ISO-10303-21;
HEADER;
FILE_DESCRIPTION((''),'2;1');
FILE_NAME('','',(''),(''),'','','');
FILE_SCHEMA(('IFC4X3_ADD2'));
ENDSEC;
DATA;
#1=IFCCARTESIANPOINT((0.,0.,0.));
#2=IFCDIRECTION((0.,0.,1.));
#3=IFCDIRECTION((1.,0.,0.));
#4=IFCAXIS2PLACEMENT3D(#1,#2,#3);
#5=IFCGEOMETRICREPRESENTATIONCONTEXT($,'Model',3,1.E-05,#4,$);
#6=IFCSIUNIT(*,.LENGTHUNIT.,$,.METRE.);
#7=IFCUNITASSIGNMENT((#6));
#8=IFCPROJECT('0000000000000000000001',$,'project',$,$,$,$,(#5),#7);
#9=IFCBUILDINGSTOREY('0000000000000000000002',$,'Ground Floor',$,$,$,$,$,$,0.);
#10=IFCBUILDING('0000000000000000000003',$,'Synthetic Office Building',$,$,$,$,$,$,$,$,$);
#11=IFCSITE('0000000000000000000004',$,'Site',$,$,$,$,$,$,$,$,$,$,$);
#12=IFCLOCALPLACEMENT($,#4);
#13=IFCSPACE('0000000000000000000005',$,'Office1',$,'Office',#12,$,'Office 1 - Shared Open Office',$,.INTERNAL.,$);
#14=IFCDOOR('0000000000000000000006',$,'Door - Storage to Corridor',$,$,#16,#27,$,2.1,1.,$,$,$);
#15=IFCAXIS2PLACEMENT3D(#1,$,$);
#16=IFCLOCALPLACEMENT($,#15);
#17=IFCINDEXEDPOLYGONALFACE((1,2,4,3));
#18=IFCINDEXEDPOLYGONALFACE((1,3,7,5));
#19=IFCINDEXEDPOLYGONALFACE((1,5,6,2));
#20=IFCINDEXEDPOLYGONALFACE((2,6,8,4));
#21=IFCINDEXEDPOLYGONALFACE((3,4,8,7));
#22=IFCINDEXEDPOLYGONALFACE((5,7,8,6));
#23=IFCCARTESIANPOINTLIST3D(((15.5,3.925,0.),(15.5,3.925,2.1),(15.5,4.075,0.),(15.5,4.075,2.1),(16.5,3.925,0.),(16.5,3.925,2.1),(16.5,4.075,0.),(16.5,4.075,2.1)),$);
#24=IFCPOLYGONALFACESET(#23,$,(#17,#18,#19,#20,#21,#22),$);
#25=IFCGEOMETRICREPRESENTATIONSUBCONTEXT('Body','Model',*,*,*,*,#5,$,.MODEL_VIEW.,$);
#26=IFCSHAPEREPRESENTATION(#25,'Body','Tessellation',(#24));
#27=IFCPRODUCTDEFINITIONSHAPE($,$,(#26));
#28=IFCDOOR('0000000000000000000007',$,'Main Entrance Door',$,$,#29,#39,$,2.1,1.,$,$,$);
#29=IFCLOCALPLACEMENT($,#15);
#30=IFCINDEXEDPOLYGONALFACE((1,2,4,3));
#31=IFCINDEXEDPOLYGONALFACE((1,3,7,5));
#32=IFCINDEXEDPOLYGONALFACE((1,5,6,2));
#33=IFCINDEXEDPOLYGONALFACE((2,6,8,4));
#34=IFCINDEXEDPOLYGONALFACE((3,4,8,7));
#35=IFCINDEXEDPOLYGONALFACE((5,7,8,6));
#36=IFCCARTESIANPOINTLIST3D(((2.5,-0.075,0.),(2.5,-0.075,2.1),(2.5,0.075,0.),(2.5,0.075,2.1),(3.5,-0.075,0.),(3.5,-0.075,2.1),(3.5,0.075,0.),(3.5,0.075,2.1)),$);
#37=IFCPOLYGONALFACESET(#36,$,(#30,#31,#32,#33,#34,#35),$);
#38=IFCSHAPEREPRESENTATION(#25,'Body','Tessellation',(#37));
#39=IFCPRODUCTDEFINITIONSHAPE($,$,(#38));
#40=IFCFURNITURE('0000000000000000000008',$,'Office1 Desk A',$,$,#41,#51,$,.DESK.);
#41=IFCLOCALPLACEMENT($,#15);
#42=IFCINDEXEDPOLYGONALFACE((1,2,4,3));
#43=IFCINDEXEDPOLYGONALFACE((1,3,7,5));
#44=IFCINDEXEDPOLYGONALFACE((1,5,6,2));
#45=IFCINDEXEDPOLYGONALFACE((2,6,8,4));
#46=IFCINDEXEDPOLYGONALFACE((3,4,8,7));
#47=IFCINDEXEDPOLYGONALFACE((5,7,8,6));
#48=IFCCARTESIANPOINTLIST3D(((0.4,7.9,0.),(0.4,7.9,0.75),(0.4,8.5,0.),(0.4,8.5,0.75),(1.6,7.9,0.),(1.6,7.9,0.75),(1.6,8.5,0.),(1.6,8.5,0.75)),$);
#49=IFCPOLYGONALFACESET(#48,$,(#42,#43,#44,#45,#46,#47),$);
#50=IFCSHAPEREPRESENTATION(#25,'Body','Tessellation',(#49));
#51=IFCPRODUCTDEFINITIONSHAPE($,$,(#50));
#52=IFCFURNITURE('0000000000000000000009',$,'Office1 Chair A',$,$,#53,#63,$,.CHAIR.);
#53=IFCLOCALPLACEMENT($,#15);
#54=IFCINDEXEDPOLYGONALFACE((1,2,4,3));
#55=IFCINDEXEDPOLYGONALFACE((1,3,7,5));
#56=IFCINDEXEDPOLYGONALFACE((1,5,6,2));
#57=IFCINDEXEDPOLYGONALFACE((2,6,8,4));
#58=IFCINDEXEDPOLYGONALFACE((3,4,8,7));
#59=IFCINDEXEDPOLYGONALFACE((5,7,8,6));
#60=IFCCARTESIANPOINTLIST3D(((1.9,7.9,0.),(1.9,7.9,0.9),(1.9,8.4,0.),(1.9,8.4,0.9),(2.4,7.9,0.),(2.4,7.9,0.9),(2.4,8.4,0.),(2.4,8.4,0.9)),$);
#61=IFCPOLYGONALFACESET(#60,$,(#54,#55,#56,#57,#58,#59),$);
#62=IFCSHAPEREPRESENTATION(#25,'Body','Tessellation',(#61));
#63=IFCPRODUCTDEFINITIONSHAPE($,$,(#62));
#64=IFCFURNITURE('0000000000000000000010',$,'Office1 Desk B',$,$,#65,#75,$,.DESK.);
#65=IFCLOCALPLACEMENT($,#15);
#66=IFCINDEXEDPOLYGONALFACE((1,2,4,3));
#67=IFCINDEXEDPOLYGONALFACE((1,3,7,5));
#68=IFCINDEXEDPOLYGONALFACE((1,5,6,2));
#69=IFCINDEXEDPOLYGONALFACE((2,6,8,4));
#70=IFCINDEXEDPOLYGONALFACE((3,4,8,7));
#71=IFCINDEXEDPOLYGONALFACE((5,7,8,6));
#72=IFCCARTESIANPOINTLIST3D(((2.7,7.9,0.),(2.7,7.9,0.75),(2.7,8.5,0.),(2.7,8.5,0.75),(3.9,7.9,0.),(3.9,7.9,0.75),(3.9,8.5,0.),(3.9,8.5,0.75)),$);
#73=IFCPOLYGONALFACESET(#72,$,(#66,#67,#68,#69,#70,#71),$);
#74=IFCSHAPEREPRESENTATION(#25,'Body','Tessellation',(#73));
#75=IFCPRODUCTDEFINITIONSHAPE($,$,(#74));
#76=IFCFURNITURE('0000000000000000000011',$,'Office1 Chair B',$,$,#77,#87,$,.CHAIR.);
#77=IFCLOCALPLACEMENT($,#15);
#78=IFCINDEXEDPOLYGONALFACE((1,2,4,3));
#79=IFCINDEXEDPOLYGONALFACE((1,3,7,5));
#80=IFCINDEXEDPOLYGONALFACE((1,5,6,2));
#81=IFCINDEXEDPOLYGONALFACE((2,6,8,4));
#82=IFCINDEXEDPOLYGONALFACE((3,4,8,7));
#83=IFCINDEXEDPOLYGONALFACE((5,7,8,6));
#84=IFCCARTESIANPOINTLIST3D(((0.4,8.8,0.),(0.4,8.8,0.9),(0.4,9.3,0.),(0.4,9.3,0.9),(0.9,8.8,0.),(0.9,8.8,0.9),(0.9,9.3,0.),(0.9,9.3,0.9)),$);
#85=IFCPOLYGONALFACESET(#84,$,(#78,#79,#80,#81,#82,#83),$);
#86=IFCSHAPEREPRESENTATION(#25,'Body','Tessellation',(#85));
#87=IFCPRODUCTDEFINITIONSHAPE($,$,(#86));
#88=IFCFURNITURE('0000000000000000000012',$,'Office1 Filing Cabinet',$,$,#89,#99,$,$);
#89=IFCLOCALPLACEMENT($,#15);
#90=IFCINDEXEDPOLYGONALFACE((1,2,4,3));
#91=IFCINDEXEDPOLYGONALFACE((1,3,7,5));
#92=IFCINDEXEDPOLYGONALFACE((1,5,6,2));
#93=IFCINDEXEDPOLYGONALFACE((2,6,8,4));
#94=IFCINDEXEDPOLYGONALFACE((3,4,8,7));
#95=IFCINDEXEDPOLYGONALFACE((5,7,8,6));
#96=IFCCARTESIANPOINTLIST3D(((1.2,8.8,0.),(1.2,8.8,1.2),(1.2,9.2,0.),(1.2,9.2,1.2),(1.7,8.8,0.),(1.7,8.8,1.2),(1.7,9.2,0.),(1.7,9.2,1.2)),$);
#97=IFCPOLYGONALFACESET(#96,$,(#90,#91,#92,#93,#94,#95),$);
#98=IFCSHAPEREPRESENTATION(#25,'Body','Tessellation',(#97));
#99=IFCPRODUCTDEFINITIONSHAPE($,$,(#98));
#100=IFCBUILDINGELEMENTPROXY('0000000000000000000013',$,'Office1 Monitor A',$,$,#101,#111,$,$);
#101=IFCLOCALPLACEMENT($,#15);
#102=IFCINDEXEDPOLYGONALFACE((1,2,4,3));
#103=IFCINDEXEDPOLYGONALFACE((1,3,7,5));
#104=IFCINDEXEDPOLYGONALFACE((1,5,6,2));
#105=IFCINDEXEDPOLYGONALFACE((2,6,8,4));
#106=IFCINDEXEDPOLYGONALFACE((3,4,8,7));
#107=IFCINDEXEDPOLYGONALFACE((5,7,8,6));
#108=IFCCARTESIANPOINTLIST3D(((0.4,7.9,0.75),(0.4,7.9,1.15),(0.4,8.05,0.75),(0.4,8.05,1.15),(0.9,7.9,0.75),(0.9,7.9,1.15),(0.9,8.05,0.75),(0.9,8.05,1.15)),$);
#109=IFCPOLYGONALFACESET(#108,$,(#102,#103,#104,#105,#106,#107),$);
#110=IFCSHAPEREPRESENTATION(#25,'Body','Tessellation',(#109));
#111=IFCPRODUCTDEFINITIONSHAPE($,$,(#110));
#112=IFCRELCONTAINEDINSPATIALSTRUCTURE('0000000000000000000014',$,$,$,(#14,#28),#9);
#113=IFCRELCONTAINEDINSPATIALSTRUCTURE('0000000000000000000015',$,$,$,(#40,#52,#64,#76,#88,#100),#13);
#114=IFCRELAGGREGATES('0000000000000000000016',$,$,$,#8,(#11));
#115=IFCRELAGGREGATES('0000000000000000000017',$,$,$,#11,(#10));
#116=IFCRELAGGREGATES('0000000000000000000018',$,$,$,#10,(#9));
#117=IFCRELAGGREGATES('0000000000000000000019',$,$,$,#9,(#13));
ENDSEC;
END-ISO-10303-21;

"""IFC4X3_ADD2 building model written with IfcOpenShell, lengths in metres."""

from ifc_helpers import new_model, si_unit, frame, origin_with_axes, place, context, subcontext, project, spatial, polyline, outline, extrude, element, save


model = new_model("IFC4X3_ADD2")

# Units and contexts
model_context = context("Model", 3, precision=1e-05, world=origin_with_axes())
body_context = subcontext(model_context, "Body", "Model", "MODEL_VIEW")
ifc_project = project(units=[si_unit("LENGTHUNIT", "METRE")], contexts=[model_context])

# Site, building, storey
site = spatial("IfcSite", under=ifc_project, Name="Site")
building = spatial("IfcBuilding", under=site, Name="Synthetic Office Building")
storey = spatial("IfcBuildingStorey", under=building, Name="Ground Floor", Elevation=0.0)

# Doors
door_1_placement = place(None, origin_with_axes())
element("IfcDoor", 1, at=door_1_placement, inside=storey, Name="Door - Storage to Corridor", OverallHeight=2.1, OverallWidth=1.0, context=body_context, shape_type="SweptSolid", body=[
    extrude(outline(polyline([(15.5, 3.925), (16.5, 3.925), (16.5, 4.075), (15.5, 4.075), (15.5, 3.925)])), origin_with_axes(), (0.0, 0.0, 1.0), 2.1),
])
door_2_placement = place(None, origin_with_axes())
element("IfcDoor", 2, at=door_2_placement, inside=storey, Name="Main Entrance Door", OverallHeight=2.1, OverallWidth=1.0, context=body_context, shape_type="SweptSolid", body=[
    extrude(outline(polyline([(2.5, -0.075), (3.5, -0.075), (3.5, 0.075), (2.5, 0.075), (2.5, -0.075)])), origin_with_axes(), (0.0, 0.0, 1.0), 2.1),
])

# Shared definitions
space_placement = place(None, origin_with_axes())
space = spatial("IfcSpace", under=storey, at=space_placement, Name="Office1", ObjectType="Office", LongName="Office 1 - Shared Open Office", PredefinedType="INTERNAL")

# Furniture
furniture_1_placement = place(space_placement, origin_with_axes())
element("IfcFurniture", 3, at=furniture_1_placement, inside=space, Name="Office1 Desk A", PredefinedType="DESK", context=body_context, shape_type="SweptSolid", body=[
    extrude(outline(polyline([(0.4, 7.9), (1.6, 7.9), (1.6, 8.5), (0.4, 8.5), (0.4, 7.9)])), origin_with_axes(), (0.0, 0.0, 1.0), 0.75),
])
furniture_2_placement = place(space_placement, origin_with_axes())
element("IfcFurniture", 4, at=furniture_2_placement, inside=space, Name="Office1 Chair A", PredefinedType="CHAIR", context=body_context, shape_type="SweptSolid", body=[
    extrude(outline(polyline([(1.9, 7.9), (2.4, 7.9), (2.4, 8.4), (1.9, 8.4), (1.9, 7.9)])), origin_with_axes(), (0.0, 0.0, 1.0), 0.9),
])
furniture_3_placement = place(space_placement, origin_with_axes())
element("IfcFurniture", 5, at=furniture_3_placement, inside=space, Name="Office1 Desk B", PredefinedType="DESK", context=body_context, shape_type="SweptSolid", body=[
    extrude(outline(polyline([(2.7, 7.9), (3.9, 7.9), (3.9, 8.5), (2.7, 8.5), (2.7, 7.9)])), origin_with_axes(), (0.0, 0.0, 1.0), 0.75),
])
furniture_4_placement = place(space_placement, origin_with_axes())
element("IfcFurniture", 6, at=furniture_4_placement, inside=space, Name="Office1 Chair B", PredefinedType="CHAIR", context=body_context, shape_type="SweptSolid", body=[
    extrude(outline(polyline([(0.4, 8.8), (0.9, 8.8), (0.9, 9.3), (0.4, 9.3), (0.4, 8.8)])), origin_with_axes(), (0.0, 0.0, 1.0), 0.9),
])
furniture_5_placement = place(space_placement, origin_with_axes())
element("IfcFurniture", 7, at=furniture_5_placement, inside=space, Name="Office1 Filing Cabinet", context=body_context, shape_type="SweptSolid", body=[
    extrude(outline(polyline([(1.2, 8.8), (1.7, 8.8), (1.7, 9.2), (1.2, 9.2), (1.2, 8.8)])), origin_with_axes(), (0.0, 0.0, 1.0), 1.2),
])

# Building element proxy
proxy_placement = place(space_placement, origin_with_axes())
element("IfcBuildingElementProxy", 8, at=proxy_placement, inside=space, Name="Office1 Monitor A", context=body_context, shape_type="SweptSolid", body=[
    extrude(outline(polyline([(0.4, 7.9), (0.9, 7.9), (0.9, 8.05), (0.4, 8.05), (0.4, 7.9)])), frame((0.0, 0.0, 0.75), z_axis=(0.0, 0.0, 1.0), x_axis=(1.0, 0.0, 0.0)), (0.0, 0.0, 1.0), 0.4),
])

save(model, "model.ifc")
